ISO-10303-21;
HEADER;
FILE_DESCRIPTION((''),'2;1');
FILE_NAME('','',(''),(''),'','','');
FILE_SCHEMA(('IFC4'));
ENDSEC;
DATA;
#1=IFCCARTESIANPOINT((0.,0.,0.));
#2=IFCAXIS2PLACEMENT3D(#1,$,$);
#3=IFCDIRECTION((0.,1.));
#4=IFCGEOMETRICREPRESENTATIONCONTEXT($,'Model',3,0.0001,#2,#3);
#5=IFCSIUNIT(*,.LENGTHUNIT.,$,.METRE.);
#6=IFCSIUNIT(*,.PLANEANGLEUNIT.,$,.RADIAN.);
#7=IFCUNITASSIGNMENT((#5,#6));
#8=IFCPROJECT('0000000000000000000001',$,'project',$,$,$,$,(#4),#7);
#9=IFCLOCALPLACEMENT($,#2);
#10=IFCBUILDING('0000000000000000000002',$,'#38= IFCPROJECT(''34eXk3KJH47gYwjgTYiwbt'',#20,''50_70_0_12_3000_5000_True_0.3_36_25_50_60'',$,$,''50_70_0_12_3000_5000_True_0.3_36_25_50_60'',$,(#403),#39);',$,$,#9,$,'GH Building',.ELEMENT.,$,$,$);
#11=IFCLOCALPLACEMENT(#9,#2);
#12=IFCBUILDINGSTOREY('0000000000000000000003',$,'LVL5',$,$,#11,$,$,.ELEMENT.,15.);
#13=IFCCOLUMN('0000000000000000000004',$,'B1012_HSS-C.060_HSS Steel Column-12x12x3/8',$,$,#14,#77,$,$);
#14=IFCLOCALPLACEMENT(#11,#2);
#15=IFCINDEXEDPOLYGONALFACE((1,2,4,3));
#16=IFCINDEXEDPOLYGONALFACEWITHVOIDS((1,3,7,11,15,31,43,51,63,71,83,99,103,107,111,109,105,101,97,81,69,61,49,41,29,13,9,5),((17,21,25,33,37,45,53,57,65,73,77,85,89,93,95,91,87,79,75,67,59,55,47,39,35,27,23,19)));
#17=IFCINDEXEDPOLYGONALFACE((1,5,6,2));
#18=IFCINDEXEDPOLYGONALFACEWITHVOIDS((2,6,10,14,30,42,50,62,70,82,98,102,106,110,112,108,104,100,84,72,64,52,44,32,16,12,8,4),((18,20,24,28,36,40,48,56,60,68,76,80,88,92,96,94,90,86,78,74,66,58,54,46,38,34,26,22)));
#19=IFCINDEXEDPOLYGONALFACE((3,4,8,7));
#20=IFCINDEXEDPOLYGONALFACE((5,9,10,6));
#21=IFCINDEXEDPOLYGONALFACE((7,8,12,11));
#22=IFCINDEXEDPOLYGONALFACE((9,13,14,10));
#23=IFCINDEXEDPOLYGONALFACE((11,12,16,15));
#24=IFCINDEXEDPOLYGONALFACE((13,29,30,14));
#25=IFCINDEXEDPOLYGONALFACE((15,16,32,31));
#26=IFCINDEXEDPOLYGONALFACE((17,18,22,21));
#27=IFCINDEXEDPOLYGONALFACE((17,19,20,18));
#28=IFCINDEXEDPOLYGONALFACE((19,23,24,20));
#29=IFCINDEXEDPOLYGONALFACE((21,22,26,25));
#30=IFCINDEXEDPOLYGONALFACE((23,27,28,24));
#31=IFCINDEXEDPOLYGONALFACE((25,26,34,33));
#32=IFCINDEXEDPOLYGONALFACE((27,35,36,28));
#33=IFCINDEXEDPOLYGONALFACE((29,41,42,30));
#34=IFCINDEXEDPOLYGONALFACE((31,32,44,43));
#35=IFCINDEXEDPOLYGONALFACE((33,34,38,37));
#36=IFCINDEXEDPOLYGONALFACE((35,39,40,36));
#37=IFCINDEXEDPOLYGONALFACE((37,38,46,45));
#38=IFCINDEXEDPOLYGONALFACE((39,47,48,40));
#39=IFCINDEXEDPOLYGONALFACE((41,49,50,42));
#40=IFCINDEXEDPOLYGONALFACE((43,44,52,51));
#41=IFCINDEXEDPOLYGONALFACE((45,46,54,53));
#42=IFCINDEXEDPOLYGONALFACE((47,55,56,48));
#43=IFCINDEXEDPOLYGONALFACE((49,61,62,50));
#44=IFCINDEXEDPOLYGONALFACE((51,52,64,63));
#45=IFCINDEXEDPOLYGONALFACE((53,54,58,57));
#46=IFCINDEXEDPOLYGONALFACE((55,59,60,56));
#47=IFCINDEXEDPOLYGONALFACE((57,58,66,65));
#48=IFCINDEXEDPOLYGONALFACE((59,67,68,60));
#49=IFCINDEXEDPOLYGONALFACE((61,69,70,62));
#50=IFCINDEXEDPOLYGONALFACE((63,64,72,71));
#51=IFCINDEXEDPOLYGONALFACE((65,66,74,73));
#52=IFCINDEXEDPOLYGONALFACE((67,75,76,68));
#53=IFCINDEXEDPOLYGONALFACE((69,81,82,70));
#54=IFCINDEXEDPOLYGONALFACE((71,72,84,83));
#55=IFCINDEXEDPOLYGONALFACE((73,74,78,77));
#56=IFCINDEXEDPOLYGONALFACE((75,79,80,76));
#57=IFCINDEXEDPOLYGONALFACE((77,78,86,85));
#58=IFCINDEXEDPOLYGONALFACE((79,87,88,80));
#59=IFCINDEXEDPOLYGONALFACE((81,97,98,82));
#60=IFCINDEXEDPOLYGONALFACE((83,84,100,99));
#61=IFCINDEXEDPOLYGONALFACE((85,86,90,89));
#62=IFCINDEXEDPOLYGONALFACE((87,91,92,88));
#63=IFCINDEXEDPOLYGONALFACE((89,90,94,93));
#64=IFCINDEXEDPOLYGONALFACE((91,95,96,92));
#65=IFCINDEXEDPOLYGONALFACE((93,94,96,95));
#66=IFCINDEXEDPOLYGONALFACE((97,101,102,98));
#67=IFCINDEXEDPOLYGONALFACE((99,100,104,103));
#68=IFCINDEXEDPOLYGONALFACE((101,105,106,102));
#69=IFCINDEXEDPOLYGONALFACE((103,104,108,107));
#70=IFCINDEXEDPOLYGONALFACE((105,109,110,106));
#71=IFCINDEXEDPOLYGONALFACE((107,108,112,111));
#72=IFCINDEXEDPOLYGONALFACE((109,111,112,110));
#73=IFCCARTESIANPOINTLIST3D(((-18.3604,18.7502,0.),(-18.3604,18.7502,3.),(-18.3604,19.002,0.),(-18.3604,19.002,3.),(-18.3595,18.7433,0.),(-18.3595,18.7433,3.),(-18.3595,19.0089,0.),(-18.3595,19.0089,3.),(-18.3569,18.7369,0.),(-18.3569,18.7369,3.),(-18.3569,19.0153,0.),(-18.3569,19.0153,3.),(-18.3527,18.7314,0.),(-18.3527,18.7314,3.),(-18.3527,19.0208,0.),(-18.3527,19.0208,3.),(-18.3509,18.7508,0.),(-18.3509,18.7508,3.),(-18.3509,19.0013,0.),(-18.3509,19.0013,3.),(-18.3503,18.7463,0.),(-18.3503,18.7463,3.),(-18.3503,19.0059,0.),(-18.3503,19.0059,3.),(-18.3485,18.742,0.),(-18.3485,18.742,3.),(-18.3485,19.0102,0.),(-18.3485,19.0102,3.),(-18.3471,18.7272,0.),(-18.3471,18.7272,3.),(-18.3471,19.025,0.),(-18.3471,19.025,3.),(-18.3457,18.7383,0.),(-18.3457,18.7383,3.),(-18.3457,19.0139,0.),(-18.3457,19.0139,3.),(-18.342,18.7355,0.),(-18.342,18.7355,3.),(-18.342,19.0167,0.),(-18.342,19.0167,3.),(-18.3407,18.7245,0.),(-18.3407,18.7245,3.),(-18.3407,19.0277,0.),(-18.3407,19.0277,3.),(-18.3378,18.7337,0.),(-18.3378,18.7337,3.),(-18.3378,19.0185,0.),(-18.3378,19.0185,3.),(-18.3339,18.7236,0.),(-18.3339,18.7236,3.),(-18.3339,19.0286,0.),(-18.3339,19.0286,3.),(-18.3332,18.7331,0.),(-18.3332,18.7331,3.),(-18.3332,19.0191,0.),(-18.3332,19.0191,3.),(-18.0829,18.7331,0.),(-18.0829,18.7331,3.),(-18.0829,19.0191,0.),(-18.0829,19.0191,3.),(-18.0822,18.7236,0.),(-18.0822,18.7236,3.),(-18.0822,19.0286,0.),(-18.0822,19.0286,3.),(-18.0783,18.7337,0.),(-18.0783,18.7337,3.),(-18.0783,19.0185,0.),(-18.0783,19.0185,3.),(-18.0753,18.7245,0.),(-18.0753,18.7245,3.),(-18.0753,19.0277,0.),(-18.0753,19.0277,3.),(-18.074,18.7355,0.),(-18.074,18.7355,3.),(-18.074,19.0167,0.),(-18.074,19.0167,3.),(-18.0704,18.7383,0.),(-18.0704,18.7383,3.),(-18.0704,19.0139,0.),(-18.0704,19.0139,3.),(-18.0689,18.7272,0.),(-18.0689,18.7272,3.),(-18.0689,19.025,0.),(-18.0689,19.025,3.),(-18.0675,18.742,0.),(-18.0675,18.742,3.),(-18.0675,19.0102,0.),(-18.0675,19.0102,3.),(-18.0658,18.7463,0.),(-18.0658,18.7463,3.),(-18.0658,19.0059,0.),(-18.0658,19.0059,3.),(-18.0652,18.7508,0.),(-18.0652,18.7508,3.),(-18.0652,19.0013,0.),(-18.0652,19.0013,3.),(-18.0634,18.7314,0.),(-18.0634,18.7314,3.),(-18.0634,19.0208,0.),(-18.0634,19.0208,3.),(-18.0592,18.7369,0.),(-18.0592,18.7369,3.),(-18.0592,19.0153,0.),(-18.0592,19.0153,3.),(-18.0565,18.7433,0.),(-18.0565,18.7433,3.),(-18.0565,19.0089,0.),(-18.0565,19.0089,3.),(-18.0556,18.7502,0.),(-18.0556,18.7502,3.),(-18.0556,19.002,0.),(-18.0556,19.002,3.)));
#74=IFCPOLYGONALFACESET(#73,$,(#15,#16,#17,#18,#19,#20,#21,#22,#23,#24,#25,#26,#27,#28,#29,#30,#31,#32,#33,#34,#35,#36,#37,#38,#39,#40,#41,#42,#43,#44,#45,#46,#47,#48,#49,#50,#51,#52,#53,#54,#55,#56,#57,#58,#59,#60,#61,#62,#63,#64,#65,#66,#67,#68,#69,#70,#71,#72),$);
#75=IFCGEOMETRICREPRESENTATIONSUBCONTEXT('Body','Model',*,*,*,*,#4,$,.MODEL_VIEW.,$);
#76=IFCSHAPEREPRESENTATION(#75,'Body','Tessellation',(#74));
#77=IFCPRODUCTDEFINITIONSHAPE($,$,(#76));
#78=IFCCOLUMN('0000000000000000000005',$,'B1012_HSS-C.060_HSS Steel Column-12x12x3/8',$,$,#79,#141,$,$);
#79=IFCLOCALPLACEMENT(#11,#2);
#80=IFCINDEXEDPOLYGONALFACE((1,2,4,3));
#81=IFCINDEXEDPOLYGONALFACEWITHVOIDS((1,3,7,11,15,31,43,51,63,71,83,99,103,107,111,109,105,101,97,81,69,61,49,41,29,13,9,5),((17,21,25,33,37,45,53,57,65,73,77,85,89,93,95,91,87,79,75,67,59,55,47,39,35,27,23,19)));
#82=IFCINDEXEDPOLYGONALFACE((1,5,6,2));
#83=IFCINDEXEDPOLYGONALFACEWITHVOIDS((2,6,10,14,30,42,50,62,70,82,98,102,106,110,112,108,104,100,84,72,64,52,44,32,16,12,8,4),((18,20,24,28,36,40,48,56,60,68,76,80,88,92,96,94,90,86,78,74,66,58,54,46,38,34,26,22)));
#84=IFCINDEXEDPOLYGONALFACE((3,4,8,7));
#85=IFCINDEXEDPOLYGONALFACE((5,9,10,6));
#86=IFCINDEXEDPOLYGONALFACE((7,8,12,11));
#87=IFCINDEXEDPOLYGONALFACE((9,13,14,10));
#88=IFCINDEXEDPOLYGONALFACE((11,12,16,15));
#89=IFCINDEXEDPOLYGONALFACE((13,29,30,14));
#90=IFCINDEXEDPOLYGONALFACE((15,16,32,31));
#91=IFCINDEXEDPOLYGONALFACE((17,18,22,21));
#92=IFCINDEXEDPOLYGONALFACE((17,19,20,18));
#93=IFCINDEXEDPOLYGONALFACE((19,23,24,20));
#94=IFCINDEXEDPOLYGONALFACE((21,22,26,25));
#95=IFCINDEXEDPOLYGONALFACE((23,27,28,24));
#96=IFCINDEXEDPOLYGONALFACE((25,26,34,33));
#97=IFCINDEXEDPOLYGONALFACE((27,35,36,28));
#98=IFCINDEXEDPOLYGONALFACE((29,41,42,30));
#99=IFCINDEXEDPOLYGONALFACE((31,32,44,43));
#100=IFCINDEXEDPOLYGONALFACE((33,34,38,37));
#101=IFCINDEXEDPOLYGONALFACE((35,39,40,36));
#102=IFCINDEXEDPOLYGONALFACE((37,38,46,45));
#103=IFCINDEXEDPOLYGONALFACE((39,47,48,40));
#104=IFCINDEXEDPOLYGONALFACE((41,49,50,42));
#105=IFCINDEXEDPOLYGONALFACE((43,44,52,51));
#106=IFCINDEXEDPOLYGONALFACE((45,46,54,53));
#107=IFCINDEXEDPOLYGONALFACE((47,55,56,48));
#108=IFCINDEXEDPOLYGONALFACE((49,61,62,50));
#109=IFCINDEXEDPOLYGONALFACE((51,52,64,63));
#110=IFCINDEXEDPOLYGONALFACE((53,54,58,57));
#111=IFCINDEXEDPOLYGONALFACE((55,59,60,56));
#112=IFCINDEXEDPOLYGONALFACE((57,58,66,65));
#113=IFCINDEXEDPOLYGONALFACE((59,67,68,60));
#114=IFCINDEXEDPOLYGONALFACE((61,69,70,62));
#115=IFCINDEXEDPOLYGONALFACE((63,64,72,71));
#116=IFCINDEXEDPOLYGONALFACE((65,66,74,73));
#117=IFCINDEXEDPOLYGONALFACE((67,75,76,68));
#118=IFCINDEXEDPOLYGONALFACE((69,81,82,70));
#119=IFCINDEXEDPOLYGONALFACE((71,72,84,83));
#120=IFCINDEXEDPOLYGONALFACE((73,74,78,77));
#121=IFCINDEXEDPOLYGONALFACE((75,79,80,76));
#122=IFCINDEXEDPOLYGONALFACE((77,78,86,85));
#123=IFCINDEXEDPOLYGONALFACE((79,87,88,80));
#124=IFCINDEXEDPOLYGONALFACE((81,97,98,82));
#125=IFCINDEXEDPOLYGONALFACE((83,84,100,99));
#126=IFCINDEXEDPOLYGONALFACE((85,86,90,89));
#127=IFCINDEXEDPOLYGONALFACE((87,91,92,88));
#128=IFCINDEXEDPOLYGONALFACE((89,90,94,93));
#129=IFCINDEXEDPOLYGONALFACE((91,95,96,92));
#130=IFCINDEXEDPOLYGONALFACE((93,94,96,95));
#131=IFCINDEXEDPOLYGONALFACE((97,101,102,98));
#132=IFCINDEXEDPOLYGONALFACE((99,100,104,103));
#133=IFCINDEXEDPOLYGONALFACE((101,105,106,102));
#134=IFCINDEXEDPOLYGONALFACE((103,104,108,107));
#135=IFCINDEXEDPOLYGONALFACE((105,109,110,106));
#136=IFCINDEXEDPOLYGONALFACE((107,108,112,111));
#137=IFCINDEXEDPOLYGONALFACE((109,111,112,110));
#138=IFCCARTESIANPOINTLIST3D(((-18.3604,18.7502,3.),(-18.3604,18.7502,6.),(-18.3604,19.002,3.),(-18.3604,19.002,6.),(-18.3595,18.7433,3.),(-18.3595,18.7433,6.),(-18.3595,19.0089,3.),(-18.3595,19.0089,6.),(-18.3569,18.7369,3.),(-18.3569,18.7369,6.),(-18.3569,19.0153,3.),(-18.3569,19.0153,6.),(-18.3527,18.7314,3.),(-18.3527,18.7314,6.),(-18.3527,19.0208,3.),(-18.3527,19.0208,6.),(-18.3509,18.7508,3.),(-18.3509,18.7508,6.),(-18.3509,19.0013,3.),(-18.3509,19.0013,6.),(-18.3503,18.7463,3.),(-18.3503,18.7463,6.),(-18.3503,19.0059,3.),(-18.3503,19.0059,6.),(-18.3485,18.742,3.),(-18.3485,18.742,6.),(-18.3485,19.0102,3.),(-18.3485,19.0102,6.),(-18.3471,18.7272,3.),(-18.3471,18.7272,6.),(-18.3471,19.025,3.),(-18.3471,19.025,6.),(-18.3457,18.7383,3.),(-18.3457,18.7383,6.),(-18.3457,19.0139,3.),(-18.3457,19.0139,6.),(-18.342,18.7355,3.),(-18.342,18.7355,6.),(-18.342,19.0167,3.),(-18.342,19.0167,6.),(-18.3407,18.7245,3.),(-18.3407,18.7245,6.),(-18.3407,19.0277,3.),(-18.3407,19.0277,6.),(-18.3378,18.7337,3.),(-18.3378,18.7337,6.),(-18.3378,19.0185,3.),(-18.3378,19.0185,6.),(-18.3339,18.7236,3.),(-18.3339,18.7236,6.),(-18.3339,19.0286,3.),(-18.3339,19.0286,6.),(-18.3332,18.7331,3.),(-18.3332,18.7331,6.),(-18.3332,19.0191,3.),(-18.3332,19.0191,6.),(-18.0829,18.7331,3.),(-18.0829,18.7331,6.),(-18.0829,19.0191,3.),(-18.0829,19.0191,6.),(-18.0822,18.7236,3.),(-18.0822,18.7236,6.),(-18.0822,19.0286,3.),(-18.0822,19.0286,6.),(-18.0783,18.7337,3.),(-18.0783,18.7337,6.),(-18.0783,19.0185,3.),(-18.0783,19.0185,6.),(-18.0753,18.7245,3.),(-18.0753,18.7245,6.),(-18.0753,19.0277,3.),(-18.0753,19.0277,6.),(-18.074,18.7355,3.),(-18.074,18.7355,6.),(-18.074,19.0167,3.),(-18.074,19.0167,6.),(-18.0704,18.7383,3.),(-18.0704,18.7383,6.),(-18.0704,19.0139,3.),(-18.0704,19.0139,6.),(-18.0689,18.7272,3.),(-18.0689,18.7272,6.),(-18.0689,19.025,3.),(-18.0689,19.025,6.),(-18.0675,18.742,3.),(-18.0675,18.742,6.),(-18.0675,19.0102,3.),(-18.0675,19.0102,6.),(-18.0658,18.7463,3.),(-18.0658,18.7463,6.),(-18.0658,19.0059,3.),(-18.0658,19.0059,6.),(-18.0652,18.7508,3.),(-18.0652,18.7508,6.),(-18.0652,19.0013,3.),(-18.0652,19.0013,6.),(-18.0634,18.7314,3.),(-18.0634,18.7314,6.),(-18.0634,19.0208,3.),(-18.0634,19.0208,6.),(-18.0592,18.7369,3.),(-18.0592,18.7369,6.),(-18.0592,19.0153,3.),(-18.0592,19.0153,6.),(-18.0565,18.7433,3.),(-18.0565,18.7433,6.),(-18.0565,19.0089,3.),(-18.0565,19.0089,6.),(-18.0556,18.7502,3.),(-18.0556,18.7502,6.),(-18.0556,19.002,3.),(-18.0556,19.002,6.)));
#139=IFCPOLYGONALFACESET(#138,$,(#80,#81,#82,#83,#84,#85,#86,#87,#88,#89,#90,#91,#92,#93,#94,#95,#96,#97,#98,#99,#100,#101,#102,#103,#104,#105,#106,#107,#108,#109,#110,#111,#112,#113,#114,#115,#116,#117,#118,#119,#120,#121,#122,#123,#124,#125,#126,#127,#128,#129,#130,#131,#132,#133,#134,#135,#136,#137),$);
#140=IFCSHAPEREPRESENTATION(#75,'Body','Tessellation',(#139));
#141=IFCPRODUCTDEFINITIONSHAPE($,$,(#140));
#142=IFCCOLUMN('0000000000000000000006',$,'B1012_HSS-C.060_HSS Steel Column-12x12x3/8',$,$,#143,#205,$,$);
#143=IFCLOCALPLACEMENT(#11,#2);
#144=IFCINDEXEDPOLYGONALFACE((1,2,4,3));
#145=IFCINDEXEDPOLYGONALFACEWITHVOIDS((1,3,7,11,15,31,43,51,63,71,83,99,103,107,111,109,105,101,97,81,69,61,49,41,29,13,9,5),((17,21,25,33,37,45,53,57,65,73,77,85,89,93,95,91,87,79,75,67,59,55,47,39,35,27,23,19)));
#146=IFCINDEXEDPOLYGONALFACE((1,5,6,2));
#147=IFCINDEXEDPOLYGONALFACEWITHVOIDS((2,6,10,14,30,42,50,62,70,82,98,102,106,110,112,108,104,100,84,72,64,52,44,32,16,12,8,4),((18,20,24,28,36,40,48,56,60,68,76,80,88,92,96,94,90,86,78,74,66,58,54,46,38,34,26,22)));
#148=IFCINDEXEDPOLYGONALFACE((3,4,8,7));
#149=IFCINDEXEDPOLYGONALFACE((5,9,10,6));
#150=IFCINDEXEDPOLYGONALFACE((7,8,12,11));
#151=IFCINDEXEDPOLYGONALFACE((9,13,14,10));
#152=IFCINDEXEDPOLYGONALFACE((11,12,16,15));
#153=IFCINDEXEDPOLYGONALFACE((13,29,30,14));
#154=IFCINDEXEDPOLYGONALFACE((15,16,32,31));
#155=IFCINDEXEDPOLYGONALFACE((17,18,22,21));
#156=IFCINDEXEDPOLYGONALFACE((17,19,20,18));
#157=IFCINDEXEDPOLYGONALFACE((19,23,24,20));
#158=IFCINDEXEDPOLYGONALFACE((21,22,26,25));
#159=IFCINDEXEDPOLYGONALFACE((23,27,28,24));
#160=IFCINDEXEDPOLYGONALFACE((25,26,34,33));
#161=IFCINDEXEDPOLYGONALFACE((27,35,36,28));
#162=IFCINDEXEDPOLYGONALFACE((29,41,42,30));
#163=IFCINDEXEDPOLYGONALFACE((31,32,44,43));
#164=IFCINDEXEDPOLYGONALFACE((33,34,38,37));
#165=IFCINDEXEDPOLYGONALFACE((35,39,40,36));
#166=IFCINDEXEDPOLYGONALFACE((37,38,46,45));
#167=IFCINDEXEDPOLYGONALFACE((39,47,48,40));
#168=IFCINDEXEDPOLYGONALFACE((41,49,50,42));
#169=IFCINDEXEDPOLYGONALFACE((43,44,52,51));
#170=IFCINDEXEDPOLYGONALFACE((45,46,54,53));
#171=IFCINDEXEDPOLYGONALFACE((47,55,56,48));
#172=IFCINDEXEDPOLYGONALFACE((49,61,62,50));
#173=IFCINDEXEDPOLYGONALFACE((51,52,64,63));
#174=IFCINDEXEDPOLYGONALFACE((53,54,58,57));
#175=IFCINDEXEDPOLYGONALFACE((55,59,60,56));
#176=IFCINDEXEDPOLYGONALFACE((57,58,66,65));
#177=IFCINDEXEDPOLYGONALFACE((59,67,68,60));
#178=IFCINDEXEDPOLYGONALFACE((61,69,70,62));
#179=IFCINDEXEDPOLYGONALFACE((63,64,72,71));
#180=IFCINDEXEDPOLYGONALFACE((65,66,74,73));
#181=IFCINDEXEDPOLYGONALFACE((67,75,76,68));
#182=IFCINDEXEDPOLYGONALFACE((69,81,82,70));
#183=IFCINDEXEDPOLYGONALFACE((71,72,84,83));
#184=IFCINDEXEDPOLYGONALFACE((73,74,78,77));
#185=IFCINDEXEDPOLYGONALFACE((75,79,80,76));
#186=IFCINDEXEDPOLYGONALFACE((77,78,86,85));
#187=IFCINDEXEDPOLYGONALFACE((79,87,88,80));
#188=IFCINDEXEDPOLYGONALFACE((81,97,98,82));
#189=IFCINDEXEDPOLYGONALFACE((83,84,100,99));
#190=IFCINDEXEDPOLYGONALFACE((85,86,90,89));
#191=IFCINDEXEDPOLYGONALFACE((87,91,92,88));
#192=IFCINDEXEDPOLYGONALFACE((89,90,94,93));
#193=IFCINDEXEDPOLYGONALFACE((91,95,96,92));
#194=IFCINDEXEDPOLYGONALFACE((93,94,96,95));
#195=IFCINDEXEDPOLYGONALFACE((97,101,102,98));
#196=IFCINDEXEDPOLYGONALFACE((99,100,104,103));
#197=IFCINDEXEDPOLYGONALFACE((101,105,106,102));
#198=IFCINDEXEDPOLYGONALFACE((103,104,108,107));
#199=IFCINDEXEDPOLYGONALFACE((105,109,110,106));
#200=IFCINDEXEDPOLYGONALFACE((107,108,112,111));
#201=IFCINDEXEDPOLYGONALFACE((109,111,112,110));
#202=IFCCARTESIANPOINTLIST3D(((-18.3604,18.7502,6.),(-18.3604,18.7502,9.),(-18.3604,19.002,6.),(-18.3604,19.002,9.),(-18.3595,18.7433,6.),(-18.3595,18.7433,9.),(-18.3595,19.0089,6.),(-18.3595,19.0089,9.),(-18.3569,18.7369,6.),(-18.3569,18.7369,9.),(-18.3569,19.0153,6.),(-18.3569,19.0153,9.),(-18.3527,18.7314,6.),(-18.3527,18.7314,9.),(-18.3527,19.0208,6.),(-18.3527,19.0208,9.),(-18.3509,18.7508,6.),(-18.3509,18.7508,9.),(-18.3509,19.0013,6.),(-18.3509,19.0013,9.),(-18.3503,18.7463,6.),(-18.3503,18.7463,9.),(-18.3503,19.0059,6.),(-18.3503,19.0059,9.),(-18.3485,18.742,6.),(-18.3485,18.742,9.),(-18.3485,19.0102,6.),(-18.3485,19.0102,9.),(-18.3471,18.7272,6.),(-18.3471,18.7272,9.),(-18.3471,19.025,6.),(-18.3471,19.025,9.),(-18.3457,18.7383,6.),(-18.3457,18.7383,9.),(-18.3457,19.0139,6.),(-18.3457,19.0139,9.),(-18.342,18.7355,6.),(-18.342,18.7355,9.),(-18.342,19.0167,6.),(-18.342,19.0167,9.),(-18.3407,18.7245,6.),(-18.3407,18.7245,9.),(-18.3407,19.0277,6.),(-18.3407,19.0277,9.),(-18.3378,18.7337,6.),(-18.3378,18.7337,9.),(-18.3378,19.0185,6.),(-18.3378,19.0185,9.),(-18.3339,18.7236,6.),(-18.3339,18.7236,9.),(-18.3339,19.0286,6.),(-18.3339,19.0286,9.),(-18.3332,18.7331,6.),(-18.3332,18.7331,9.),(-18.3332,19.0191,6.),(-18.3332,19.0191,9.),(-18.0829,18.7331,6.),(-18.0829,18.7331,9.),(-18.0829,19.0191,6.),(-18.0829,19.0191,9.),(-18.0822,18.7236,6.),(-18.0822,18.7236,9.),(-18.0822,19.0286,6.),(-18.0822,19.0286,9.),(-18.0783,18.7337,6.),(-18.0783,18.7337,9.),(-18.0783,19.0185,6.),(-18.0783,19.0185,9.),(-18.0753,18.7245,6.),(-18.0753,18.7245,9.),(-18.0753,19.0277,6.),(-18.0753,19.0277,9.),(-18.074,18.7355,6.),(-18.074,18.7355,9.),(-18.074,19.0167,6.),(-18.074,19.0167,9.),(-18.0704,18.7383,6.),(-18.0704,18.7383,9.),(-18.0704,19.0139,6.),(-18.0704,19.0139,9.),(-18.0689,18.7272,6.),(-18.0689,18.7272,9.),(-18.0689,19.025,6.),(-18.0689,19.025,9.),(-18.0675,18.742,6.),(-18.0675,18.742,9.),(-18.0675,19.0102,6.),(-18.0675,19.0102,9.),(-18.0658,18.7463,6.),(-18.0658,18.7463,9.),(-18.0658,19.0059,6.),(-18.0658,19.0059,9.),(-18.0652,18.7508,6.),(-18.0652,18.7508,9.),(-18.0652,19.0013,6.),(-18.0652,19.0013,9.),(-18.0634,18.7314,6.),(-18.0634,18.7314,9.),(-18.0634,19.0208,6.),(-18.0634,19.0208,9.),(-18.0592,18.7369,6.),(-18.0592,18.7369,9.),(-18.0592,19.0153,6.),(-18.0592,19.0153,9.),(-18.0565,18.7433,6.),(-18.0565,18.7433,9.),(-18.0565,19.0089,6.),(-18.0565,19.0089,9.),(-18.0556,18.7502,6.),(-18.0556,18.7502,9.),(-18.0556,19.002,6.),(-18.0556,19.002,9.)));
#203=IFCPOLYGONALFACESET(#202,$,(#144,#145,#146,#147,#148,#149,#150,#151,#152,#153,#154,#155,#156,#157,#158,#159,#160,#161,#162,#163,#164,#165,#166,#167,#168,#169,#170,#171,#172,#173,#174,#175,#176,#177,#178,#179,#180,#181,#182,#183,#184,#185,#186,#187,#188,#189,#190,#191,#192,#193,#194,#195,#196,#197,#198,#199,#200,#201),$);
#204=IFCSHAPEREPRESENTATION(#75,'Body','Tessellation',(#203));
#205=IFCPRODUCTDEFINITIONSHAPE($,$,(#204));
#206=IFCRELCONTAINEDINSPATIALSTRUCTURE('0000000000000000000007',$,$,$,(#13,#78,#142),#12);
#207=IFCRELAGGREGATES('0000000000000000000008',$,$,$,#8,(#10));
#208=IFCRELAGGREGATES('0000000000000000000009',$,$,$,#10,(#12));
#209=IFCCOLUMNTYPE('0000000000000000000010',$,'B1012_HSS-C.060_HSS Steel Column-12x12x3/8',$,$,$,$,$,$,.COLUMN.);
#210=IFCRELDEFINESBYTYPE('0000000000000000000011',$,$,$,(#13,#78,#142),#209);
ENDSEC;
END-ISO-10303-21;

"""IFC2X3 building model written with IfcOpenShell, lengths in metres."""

from ifc_helpers import new_model, si_unit, direction, frame, origin, origin_2d, place, context, subcontext, project, spatial, hollow_rectangle, extrude, type_object, element, save


model = new_model("IFC2X3")

# Units and contexts
model_context = context("Model", 3, precision=0.0001, world=origin(), true_north=direction((0.0, 1.0)))
body_context = subcontext(model_context, "Body", "Model", "MODEL_VIEW")
ifc_project = project(units=[si_unit("LENGTHUNIT", "METRE"), si_unit("PLANEANGLEUNIT", "RADIAN")], contexts=[model_context])

# Building, storey
building_placement = place(None, origin())
building = spatial("IfcBuilding", under=ifc_project, at=building_placement, Name="#38= IFCPROJECT('34eXk3KJH47gYwjgTYiwbt',#20,'50_70_0_12_3000_5000_True_0.3_36_25_50_60',$,$,'50_70_0_12_3000_5000_True_0.3_36_25_50_60',$,(#403),#39);", LongName="GH Building", CompositionType="ELEMENT")
storey_placement = place(building_placement, origin())
storey = spatial("IfcBuildingStorey", under=building, at=storey_placement, Name="LVL5", CompositionType="ELEMENT", Elevation=15.0)

# Columns
column_type = type_object("IfcColumnType", Name="B1012_HSS-C.060_HSS Steel Column-12x12x3/8", PredefinedType="COLUMN")
for number, where, z_axis, x_axis, name in (
    (1, (-18.208, 18.8761, 3.0), (0.0, 0.0, -1.0), (-1.0, 0.0, 0.0), "B1012_HSS-C.060_HSS Steel Column-12x12x3/8"),
    (2, (-18.208, 18.8761, 6.0), (0.0, 0.0, -1.0), (-1.0, 0.0, 0.0), "B1012_HSS-C.060_HSS Steel Column-12x12x3/8"),
    (3, (-18.208, 18.8761, 9.0), (0.0, 0.0, -1.0), (-1.0, 0.0, 0.0), "B1012_HSS-C.060_HSS Steel Column-12x12x3/8"),
):
    element("IfcColumn", number, at=place(storey_placement, frame(where, z_axis=z_axis, x_axis=x_axis)), inside=storey, type_object=column_type, Name=name, context=body_context, shape_type="SweptSolid", body=[
        extrude(hollow_rectangle(XDim=0.3048, YDim=0.305, WallThickness=0.0095, InnerFilletRadius=0.0177, OuterFilletRadius=0.0266, at=origin_2d()), origin(), (0.0, 0.0, 1.0), 3.0),
    ])

save(model, "model.ifc")
